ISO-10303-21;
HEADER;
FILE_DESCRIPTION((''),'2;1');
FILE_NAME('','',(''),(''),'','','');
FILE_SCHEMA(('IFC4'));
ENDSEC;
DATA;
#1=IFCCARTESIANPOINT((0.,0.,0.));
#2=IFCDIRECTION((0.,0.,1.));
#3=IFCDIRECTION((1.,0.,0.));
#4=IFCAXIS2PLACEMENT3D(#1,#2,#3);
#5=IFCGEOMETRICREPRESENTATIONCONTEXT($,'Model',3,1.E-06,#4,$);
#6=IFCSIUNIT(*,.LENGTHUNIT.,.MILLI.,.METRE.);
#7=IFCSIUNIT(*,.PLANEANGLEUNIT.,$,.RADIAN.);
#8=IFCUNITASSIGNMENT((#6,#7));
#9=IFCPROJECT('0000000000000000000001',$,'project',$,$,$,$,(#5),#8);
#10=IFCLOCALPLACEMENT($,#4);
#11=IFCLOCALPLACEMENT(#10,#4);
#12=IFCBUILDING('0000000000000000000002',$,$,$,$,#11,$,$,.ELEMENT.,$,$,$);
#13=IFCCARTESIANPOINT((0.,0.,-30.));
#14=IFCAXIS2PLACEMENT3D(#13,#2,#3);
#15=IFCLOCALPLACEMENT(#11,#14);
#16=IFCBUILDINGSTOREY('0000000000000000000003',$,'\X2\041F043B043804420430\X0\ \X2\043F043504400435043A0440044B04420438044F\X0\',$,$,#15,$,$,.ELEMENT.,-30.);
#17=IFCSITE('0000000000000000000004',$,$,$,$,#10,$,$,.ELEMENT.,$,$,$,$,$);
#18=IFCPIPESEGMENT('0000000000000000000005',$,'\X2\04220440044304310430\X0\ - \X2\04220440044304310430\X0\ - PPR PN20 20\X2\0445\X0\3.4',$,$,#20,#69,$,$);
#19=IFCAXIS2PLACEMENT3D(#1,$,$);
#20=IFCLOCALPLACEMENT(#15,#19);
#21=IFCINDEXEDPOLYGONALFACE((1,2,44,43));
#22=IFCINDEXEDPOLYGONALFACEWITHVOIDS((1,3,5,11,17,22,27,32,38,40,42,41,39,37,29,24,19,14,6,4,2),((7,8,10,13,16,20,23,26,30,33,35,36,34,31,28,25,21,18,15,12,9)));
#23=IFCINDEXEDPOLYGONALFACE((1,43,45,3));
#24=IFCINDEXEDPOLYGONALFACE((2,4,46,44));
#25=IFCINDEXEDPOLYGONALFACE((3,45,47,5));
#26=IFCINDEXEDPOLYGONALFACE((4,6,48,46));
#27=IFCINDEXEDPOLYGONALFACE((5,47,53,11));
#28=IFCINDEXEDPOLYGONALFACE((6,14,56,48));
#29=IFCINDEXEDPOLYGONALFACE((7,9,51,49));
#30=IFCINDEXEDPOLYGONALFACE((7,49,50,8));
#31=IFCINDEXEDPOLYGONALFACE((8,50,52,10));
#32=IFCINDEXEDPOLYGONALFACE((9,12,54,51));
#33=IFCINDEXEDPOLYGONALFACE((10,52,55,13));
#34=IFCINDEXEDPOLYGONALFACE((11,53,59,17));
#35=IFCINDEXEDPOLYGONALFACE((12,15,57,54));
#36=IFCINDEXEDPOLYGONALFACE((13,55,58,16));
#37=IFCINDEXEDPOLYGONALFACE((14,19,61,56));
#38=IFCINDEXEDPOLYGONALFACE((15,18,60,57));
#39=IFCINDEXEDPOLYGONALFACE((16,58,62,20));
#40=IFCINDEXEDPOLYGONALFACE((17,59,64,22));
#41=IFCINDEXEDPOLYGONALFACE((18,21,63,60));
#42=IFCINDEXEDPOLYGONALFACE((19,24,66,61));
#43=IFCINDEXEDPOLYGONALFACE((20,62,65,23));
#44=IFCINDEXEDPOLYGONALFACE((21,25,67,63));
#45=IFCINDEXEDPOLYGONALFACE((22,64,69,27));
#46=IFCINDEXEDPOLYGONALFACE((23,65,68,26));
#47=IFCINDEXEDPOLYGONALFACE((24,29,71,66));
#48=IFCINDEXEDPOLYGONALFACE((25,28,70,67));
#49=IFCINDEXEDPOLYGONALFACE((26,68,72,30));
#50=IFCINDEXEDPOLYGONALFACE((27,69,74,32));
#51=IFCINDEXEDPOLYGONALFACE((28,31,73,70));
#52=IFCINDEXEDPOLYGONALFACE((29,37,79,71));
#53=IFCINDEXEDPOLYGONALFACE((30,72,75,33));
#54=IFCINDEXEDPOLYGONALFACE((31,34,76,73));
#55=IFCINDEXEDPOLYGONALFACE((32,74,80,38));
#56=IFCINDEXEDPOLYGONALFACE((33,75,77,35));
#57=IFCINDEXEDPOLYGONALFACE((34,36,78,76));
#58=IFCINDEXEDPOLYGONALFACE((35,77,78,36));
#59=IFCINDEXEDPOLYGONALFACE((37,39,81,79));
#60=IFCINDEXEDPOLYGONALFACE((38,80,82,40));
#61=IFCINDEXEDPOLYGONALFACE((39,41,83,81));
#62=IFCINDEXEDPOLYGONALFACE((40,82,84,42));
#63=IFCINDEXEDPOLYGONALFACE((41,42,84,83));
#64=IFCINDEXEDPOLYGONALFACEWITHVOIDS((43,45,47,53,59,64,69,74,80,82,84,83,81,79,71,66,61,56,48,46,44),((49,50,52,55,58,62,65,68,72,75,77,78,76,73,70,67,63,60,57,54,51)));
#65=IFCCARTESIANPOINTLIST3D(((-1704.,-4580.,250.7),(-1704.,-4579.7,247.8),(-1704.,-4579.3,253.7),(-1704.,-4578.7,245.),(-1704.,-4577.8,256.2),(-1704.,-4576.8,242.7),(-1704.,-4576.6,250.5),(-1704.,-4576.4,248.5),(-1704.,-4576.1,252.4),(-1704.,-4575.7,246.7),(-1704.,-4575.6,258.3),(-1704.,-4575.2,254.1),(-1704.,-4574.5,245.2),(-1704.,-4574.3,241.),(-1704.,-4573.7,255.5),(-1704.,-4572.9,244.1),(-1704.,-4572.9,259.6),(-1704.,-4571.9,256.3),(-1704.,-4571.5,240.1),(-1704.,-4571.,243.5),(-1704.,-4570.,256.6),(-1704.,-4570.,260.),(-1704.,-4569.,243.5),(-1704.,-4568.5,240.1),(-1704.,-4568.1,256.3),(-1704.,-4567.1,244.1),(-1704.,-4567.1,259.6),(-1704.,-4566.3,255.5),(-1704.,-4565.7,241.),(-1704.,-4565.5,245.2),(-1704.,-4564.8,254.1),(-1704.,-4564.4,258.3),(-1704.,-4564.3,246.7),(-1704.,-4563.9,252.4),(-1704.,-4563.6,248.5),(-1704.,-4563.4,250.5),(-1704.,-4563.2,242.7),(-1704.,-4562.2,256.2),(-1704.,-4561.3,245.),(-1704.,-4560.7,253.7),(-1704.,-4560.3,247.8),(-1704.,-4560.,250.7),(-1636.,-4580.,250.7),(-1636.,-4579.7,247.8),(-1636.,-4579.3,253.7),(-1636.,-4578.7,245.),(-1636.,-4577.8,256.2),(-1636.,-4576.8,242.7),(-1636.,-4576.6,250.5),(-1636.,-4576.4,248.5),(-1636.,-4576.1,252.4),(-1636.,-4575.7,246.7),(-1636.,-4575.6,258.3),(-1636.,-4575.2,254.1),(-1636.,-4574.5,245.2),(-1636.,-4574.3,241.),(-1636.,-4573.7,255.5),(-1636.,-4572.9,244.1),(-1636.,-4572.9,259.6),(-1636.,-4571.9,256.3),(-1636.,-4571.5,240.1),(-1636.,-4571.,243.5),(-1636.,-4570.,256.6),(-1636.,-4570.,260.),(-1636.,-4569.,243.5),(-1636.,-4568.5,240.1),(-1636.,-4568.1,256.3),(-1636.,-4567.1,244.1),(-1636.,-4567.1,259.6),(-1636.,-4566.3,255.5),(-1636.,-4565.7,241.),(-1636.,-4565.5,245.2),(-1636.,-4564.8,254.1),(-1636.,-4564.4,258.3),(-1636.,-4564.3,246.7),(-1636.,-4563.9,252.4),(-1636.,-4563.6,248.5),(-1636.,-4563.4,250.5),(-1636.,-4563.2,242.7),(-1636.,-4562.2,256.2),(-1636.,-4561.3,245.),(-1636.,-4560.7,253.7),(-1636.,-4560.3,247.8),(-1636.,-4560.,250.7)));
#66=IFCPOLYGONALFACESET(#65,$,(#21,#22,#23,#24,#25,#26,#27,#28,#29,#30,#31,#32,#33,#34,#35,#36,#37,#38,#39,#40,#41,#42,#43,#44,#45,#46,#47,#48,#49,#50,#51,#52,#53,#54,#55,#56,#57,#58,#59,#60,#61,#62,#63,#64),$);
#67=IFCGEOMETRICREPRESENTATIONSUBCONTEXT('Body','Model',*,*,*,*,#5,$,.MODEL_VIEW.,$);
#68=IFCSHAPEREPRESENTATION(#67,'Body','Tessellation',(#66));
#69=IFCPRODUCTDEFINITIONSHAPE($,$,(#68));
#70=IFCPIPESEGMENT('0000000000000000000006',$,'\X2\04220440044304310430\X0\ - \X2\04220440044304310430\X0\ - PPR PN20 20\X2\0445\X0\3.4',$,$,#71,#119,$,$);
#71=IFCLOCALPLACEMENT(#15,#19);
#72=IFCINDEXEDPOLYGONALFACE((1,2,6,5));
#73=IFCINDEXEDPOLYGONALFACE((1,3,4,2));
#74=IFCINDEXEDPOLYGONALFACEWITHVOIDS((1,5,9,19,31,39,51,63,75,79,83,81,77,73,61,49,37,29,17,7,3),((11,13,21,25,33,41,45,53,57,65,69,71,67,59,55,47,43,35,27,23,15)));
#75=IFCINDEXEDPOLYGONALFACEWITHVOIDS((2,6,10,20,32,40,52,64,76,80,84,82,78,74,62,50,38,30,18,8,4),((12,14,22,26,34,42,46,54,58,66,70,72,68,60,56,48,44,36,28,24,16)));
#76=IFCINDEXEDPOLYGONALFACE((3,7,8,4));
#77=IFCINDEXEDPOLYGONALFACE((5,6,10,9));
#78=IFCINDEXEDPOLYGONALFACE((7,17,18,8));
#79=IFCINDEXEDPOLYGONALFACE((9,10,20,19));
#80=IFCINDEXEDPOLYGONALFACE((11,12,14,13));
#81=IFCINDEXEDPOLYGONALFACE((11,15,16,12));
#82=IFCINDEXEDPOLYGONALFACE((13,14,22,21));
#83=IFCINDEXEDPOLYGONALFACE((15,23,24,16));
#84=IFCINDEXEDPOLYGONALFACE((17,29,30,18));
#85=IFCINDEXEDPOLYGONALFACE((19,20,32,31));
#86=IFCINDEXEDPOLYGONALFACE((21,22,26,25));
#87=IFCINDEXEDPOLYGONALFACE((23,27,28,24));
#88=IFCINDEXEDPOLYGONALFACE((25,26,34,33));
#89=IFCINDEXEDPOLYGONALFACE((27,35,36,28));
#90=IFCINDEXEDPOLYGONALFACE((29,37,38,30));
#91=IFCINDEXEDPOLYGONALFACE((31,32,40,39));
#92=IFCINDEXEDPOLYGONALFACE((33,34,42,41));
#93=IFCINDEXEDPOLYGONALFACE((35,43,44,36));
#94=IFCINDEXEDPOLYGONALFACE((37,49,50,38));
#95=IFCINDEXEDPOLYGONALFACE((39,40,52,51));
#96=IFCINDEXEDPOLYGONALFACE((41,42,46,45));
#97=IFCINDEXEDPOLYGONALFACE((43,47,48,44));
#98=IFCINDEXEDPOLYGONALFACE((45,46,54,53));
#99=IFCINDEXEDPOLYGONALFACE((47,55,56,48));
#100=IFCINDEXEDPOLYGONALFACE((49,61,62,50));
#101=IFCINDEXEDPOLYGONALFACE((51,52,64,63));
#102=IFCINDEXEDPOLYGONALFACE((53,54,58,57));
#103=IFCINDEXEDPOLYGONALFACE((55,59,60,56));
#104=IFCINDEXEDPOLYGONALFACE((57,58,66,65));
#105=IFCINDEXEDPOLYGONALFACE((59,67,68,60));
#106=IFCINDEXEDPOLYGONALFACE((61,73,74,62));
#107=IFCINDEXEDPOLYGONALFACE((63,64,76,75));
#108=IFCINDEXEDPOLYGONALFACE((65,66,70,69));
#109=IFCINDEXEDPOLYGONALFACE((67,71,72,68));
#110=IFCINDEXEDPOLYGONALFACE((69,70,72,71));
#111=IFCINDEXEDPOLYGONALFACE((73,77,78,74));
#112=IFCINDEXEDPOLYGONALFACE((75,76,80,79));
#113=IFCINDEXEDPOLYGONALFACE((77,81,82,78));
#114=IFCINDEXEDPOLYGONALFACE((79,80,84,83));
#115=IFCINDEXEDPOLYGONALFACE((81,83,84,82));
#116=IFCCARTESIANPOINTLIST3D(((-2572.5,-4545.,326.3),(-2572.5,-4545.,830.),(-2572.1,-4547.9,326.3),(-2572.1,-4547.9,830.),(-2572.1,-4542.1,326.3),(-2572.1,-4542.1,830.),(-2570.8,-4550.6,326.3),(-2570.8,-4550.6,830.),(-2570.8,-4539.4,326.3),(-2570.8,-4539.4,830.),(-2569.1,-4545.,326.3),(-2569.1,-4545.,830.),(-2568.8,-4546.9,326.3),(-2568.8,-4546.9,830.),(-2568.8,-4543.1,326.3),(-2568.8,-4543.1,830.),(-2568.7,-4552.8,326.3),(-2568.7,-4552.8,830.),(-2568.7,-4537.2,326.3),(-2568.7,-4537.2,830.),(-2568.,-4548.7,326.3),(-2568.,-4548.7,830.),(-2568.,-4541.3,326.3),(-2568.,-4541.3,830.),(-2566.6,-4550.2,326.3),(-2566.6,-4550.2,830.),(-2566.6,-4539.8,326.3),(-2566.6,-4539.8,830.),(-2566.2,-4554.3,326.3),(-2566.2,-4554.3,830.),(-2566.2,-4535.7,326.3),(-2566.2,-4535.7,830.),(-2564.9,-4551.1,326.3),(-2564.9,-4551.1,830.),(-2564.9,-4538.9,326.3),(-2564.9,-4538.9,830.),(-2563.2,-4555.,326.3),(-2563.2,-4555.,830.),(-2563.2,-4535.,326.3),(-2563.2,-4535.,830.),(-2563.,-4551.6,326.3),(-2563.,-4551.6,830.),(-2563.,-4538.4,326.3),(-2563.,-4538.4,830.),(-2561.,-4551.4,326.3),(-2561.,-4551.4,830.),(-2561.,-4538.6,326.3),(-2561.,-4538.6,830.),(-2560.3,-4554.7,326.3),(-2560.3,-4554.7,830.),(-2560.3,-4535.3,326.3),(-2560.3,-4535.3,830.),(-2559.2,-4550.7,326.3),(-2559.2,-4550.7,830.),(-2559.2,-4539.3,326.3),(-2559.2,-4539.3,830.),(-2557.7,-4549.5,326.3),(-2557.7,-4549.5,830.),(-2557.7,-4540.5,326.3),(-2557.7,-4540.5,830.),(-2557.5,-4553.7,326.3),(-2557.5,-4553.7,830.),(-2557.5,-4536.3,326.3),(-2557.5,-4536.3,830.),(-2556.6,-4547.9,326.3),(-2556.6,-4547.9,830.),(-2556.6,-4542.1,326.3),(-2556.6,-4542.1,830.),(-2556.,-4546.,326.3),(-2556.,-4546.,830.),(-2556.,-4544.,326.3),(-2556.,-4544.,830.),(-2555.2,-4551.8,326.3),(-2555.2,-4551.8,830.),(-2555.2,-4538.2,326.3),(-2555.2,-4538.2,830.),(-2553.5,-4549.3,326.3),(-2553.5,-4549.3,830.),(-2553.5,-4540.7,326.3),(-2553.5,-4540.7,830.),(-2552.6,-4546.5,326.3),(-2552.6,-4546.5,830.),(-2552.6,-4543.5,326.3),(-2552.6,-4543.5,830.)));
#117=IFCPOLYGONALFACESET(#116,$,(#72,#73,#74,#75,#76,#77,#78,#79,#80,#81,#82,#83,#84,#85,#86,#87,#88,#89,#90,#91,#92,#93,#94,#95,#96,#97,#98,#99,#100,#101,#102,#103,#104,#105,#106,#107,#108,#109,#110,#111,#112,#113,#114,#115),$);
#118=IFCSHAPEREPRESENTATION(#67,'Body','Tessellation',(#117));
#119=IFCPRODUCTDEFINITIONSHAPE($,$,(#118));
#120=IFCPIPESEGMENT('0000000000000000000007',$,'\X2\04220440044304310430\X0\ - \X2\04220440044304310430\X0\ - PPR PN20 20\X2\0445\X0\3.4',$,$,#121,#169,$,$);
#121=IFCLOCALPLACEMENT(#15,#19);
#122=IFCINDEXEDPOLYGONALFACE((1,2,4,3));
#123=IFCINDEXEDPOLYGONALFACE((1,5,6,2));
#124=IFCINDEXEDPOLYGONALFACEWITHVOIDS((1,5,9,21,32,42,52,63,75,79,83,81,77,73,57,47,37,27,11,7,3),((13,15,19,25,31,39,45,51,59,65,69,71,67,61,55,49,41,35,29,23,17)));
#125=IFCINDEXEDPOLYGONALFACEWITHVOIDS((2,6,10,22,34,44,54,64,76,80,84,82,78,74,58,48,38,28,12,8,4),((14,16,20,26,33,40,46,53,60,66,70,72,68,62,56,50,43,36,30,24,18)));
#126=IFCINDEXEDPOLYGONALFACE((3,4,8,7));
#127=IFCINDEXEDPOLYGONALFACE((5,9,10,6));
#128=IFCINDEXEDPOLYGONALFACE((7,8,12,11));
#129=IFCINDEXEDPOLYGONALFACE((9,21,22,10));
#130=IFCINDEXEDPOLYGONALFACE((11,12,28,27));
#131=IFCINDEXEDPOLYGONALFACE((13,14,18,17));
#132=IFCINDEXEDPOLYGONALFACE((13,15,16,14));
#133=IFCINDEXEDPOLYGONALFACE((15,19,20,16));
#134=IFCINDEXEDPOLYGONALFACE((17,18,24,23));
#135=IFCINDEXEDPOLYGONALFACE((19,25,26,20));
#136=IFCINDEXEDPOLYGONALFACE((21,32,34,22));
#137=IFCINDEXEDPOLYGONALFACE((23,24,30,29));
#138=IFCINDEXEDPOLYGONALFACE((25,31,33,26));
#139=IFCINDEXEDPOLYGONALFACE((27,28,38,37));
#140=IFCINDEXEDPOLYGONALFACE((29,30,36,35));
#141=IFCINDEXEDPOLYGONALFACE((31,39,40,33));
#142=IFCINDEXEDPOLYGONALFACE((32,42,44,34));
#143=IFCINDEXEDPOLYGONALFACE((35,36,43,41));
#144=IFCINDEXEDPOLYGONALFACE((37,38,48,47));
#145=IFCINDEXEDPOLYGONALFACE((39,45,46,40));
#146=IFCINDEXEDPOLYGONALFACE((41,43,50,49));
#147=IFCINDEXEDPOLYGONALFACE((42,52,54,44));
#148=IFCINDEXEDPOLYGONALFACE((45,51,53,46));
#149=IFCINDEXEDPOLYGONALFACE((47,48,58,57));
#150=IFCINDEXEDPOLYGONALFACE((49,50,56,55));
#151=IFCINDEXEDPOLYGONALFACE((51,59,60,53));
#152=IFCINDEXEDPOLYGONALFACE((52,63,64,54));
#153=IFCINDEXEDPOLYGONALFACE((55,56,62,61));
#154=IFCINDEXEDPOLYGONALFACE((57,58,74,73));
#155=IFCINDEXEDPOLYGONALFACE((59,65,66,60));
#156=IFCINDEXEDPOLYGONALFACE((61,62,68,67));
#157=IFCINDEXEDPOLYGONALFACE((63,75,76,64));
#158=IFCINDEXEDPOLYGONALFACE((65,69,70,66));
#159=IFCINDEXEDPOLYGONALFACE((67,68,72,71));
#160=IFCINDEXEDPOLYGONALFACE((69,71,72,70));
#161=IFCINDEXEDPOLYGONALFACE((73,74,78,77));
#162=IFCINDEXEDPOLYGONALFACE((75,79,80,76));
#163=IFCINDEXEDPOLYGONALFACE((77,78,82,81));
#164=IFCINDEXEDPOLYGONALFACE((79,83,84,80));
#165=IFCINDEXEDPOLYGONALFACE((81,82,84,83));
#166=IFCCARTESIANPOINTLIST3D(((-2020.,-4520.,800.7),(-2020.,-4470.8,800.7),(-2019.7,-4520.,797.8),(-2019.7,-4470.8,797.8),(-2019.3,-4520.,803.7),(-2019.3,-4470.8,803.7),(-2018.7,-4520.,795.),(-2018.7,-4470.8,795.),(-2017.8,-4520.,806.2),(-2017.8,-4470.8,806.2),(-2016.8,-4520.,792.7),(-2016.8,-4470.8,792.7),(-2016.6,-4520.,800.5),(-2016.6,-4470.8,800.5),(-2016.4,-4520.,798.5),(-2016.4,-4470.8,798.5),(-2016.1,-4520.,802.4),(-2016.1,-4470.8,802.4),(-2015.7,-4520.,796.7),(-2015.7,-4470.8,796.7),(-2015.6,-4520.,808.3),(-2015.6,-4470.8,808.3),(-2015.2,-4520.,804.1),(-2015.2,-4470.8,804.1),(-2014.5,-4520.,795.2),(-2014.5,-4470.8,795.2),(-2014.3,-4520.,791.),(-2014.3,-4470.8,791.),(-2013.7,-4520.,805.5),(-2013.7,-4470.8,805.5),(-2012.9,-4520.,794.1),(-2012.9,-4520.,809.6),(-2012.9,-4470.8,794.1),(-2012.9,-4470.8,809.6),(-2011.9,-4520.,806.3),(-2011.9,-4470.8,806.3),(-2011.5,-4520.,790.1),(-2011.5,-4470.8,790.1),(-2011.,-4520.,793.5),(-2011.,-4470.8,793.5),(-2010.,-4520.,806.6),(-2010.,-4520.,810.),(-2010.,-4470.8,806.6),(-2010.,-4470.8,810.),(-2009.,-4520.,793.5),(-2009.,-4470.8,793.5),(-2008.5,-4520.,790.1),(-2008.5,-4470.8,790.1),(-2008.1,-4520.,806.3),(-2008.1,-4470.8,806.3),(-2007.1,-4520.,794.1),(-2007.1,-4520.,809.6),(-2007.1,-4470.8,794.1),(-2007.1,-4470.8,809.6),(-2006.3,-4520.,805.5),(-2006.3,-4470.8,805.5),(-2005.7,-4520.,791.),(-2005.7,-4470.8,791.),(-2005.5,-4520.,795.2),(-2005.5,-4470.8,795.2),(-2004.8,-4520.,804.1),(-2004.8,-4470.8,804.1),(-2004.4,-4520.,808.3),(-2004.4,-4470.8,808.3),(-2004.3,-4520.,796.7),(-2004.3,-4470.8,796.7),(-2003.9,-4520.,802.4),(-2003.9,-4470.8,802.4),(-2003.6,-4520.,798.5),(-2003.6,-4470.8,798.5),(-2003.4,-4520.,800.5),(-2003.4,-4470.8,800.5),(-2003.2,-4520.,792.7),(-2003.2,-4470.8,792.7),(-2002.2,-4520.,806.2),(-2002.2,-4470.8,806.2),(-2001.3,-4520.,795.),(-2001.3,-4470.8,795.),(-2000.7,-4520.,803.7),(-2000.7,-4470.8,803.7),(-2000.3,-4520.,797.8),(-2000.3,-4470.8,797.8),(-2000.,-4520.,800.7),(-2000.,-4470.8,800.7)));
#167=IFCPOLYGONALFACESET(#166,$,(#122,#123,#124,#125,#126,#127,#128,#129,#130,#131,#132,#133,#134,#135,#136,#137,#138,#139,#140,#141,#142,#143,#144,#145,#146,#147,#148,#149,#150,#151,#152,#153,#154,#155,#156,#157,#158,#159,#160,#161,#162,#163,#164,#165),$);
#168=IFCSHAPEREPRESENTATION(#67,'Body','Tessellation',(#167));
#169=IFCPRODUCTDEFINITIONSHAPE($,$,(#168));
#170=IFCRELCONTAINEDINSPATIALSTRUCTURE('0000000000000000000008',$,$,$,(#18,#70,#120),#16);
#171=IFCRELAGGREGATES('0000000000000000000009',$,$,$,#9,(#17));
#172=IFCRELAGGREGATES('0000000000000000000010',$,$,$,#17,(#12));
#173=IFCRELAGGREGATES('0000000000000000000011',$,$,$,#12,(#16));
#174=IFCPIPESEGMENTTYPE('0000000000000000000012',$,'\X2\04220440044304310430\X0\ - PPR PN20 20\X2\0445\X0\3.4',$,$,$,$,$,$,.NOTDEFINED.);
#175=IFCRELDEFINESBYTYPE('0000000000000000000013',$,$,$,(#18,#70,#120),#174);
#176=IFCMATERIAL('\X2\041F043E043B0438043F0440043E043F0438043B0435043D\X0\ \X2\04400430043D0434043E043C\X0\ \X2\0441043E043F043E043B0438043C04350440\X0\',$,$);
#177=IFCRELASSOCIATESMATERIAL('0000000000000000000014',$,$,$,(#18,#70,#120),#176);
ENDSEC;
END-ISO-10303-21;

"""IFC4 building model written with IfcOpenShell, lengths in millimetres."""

from ifc_helpers import new_model, entity, si_unit, frame, origin_with_axes, place, context, subcontext, project, spatial, material, type_object, element, save


model = new_model("IFC4")

# Units and contexts
model_context = context("Model", 3, precision=1e-06, world=origin_with_axes())
body_context = subcontext(model_context, "Body", "Model", "MODEL_VIEW")
ifc_project = project(units=[si_unit("LENGTHUNIT", "METRE", prefix="MILLI"), si_unit("PLANEANGLEUNIT", "RADIAN")], contexts=[model_context])

# Site, building, storey
site_placement = place(None, origin_with_axes())
site = spatial("IfcSite", under=ifc_project, at=site_placement, CompositionType="ELEMENT")
building_placement = place(site_placement, origin_with_axes())
building = spatial("IfcBuilding", under=site, at=building_placement, CompositionType="ELEMENT")
storey_placement = place(building_placement, frame((0.0, 0.0, -30.0), z_axis=(0.0, 0.0, 1.0), x_axis=(1.0, 0.0, 0.0)))
storey = spatial("IfcBuildingStorey", under=building, at=storey_placement, Name="Плита перекрытия", CompositionType="ELEMENT", Elevation=-30.0)

# Pipe segments
ifc_material_1 = material(Name="Полипропилен рандом сополимер")
pipe_segment_type_1 = type_object("IfcPipeSegmentType", Name="Труба - PPR PN20 20х3.4", PredefinedType="NOTDEFINED")
pipe_segment_1_placement = place(storey_placement, frame((-1636.0, -4570.0, 250.0), z_axis=(0.0, 0.0, 1.0), x_axis=(-1.0, 0.0, 0.0)))
element("IfcPipeSegment", 1, at=pipe_segment_1_placement, inside=storey, type_object=pipe_segment_type_1, material=ifc_material_1, Name="Труба - Труба - PPR PN20 20х3.4", context=body_context, shape_type="AdvancedSweptSolid", body=[
    entity("IfcSweptDiskSolid", entity("IfcIndexedPolyCurve", entity("IfcCartesianPointList3D", [[0.0, 0.0, 0.0], [68.0, 0.0, 0.0]]), [entity("IfcLineIndex", [1, 2])]), 10.0, 6.6),
])
pipe_segment_2_placement = place(storey_placement, frame((-2562.5, -4545.0, 830.0), z_axis=(0.0, 0.0, 1.0), x_axis=(1.0, 0.0, 0.0)))
element("IfcPipeSegment", 2, at=pipe_segment_2_placement, inside=storey, type_object=pipe_segment_type_1, material=ifc_material_1, Name="Труба - Труба - PPR PN20 20х3.4", context=body_context, shape_type="AdvancedSweptSolid", body=[
    entity("IfcSweptDiskSolid", entity("IfcIndexedPolyCurve", entity("IfcCartesianPointList3D", [[0.0, 0.0, 0.0], [0.0, 0.0, -503.7]]), [entity("IfcLineIndex", [1, 2])]), 10.0, 6.6),
])
pipe_segment_3_placement = place(storey_placement, frame((-2010.0, -4520.0, 800.0), z_axis=(0.0, 0.0, 1.0), x_axis=(0.0, 1.0, 0.0)))
element("IfcPipeSegment", 3, at=pipe_segment_3_placement, inside=storey, type_object=pipe_segment_type_1, material=ifc_material_1, Name="Труба - Труба - PPR PN20 20х3.4", context=body_context, shape_type="AdvancedSweptSolid", body=[
    entity("IfcSweptDiskSolid", entity("IfcIndexedPolyCurve", entity("IfcCartesianPointList3D", [[0.0, 0.0, 0.0], [49.2, 0.0, 0.0]]), [entity("IfcLineIndex", [1, 2])]), 10.0, 6.6),
])

save(model, "model.ifc")
